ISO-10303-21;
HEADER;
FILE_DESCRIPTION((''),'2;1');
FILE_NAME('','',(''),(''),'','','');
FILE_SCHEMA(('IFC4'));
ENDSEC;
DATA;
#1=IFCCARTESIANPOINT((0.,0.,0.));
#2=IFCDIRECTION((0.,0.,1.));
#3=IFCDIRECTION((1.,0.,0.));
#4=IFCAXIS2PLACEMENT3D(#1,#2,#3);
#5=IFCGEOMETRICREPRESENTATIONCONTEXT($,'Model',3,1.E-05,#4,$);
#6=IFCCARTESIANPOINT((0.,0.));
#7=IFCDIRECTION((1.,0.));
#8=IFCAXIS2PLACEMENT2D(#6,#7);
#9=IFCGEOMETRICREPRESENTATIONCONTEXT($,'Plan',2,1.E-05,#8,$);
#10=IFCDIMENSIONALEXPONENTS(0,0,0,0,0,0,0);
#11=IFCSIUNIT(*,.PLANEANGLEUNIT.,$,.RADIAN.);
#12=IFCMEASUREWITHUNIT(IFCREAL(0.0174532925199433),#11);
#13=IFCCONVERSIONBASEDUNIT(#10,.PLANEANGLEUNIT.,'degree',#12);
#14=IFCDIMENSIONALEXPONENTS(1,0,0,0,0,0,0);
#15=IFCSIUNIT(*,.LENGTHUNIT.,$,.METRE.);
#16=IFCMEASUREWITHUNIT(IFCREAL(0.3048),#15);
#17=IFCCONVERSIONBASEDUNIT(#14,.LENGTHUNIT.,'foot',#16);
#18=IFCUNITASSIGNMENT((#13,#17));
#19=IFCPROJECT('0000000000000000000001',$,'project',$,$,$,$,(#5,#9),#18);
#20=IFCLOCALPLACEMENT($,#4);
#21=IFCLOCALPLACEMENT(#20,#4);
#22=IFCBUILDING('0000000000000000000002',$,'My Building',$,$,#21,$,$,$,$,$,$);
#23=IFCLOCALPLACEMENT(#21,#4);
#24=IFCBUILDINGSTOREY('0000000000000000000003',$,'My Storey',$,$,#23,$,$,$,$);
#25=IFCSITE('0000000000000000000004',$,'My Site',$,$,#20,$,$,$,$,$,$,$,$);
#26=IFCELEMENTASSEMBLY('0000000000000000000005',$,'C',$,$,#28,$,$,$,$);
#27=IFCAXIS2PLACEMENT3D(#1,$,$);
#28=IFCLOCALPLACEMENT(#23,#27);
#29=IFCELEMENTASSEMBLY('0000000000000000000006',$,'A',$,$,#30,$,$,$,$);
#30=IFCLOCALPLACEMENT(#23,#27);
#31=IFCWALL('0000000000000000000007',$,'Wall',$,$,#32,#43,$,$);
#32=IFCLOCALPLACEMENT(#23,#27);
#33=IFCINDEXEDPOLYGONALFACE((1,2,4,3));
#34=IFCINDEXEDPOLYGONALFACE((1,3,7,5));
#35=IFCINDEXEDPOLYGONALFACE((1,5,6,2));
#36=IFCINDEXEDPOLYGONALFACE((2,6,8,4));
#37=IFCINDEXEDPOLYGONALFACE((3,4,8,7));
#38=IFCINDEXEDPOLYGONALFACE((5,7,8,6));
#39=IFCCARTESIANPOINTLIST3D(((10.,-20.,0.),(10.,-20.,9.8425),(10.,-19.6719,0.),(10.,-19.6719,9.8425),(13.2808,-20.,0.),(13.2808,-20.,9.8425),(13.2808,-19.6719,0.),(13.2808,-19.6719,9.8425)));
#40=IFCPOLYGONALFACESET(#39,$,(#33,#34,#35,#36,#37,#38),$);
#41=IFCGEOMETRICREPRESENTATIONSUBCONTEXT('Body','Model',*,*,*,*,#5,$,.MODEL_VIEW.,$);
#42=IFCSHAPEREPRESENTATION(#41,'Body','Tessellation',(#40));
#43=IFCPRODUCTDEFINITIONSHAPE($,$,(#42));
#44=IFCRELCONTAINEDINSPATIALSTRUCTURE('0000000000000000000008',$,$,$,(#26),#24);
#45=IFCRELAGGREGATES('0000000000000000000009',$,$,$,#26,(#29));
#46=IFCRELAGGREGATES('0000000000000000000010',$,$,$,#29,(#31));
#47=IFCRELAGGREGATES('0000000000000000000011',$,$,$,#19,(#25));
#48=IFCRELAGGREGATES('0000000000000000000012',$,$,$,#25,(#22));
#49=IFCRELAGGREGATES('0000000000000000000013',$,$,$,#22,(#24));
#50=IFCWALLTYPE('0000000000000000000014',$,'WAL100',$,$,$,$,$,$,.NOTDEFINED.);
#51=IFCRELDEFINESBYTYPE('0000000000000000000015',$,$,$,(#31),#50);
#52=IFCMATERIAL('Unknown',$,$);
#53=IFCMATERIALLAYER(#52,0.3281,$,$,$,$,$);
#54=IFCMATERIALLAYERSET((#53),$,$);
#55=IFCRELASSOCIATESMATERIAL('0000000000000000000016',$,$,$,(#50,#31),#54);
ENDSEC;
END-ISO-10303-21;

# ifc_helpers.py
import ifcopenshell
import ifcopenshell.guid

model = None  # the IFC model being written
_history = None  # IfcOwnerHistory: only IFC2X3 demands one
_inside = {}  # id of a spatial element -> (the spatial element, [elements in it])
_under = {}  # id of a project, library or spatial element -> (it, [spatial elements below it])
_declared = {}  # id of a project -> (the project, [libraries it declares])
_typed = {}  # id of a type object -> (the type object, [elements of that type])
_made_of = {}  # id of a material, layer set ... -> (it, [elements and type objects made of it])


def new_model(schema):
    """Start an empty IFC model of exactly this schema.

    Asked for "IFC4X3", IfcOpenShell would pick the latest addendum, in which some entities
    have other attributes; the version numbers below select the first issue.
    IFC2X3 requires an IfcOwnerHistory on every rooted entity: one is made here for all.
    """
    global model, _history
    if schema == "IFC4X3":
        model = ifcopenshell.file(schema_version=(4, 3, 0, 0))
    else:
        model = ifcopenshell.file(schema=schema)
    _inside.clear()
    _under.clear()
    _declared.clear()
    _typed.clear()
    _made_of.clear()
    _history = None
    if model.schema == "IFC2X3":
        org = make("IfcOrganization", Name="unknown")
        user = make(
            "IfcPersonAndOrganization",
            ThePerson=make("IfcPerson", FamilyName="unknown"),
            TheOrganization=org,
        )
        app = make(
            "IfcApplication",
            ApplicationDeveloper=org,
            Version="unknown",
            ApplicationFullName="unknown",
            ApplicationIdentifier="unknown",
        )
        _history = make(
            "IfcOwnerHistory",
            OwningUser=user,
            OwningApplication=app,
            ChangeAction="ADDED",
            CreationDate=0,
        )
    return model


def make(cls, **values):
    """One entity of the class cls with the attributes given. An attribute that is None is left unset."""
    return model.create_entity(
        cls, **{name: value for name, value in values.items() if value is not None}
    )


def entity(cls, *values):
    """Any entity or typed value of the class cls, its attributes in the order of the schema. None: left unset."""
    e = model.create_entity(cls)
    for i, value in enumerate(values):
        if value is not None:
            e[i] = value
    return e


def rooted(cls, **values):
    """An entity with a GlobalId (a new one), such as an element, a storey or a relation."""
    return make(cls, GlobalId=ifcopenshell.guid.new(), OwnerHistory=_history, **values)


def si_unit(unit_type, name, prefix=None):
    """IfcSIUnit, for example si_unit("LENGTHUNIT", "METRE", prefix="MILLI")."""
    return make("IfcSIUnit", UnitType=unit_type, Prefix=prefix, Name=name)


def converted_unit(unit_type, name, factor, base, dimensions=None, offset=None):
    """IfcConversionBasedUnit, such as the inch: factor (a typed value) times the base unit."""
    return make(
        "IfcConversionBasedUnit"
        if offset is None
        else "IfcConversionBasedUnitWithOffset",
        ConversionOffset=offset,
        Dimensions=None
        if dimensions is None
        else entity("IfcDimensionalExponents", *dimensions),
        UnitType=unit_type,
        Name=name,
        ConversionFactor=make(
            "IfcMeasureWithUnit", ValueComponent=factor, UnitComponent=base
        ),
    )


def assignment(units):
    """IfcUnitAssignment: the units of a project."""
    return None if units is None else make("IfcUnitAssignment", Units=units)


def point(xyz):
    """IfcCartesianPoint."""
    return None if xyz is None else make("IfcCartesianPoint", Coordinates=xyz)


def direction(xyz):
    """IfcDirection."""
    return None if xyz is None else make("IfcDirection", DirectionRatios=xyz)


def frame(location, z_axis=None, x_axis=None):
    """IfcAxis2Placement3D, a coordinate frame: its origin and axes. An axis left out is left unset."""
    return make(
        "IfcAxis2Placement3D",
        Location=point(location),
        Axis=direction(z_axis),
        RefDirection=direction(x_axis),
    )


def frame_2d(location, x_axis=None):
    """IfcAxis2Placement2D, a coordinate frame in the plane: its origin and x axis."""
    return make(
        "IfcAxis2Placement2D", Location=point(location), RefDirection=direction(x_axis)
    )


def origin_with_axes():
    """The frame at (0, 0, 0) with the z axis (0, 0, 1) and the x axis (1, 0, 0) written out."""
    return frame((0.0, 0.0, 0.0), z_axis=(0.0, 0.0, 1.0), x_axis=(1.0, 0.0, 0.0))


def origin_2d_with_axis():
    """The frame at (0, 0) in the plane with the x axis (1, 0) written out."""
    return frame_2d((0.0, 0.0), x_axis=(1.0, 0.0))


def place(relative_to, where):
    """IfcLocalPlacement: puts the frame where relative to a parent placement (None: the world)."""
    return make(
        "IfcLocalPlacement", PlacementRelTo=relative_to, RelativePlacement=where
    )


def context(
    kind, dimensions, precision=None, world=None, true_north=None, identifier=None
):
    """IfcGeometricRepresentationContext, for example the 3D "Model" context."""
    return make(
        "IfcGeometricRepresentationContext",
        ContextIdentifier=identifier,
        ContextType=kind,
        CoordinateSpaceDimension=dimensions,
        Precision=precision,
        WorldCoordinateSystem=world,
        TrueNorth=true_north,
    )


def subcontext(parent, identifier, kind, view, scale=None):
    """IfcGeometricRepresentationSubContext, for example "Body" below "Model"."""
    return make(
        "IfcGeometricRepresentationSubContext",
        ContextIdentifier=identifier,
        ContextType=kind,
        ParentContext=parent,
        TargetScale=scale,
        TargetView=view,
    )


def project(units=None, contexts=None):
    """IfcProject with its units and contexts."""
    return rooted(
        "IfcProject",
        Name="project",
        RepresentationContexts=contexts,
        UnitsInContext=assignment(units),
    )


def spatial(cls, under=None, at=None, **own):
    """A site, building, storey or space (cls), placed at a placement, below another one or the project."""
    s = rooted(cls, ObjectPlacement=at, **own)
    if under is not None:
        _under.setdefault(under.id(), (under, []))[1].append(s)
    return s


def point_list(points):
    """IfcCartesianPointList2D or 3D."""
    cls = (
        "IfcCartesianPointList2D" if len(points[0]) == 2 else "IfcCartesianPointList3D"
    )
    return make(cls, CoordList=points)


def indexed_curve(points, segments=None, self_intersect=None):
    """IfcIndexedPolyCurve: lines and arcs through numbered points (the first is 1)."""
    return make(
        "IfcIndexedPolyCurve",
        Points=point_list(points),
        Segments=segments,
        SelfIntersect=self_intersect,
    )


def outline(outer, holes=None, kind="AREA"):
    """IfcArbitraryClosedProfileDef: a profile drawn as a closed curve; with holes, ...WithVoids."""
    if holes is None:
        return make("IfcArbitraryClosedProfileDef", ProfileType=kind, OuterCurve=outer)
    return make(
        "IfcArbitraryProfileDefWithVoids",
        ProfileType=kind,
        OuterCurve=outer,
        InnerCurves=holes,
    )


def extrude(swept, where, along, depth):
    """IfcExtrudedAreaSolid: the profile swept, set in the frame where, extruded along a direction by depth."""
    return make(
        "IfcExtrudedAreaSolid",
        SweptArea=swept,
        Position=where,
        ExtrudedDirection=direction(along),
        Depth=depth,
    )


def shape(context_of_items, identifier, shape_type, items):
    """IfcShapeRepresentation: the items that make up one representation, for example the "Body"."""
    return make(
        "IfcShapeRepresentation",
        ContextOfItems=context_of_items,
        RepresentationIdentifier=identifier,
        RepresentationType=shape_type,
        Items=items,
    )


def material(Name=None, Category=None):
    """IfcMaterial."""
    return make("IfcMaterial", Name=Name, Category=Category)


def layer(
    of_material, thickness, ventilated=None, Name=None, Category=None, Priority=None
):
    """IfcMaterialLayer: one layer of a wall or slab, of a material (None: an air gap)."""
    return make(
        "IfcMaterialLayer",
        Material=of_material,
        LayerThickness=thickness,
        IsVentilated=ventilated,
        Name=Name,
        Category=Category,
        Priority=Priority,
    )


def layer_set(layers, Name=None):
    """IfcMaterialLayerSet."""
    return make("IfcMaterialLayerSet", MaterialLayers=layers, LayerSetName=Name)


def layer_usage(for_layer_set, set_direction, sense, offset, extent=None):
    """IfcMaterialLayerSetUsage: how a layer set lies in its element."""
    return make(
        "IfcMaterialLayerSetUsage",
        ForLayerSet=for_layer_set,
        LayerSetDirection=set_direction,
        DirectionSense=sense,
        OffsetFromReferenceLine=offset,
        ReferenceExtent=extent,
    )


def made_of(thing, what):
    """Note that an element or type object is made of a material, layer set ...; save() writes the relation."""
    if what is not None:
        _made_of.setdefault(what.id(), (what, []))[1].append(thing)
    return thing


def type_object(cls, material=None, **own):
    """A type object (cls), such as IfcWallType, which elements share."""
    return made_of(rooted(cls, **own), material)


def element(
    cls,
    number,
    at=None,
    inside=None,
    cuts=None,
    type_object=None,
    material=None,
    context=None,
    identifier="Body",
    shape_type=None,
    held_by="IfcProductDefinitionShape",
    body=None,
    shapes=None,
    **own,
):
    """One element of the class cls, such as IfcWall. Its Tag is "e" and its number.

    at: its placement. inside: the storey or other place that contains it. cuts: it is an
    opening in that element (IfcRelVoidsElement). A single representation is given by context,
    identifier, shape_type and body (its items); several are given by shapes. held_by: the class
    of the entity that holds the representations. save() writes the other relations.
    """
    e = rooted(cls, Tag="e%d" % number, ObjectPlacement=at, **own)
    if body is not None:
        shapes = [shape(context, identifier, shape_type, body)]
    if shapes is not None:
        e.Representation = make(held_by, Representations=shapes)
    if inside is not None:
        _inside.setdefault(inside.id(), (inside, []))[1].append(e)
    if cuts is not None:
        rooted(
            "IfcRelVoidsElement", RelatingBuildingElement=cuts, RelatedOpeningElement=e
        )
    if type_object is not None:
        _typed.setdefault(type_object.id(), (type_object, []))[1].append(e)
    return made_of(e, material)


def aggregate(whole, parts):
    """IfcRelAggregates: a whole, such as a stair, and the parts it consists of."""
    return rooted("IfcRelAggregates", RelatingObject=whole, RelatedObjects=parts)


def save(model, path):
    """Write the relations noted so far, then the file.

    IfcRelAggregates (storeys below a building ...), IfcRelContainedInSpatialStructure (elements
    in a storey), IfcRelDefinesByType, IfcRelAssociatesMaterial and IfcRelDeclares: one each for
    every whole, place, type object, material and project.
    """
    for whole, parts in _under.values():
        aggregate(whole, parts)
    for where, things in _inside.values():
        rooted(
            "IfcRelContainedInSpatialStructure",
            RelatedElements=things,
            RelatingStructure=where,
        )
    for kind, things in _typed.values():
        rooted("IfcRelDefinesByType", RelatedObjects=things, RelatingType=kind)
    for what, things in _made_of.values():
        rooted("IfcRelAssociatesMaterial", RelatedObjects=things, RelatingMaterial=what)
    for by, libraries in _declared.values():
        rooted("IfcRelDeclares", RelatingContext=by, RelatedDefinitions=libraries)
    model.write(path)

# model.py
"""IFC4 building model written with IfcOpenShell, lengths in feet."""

from ifc_helpers import new_model, entity, si_unit, converted_unit, frame, origin_with_axes, origin_2d_with_axis, place, context, subcontext, project, spatial, indexed_curve, outline, extrude, material, layer, layer_set, layer_usage, type_object, element, aggregate, save


model = new_model("IFC4")

# Units and contexts
model_context = context("Model", 3, precision=1e-05, world=origin_with_axes())
plan_context = context("Plan", 2, precision=1e-05, world=origin_2d_with_axis())
body_context = subcontext(model_context, "Body", "Model", "MODEL_VIEW")
ifc_project = project(units=[converted_unit("PLANEANGLEUNIT", "degree", entity("IfcReal", 0.0174532925199433), si_unit("PLANEANGLEUNIT", "RADIAN"), dimensions=[0, 0, 0, 0, 0, 0, 0]), converted_unit("LENGTHUNIT", "foot", entity("IfcReal", 0.3048), si_unit("LENGTHUNIT", "METRE"), dimensions=[1, 0, 0, 0, 0, 0, 0])], contexts=[model_context, plan_context])

# Site, building, storey
site_placement = place(None, origin_with_axes())
site = spatial("IfcSite", under=ifc_project, at=site_placement, Name="My Site")
building_placement = place(site_placement, origin_with_axes())
building = spatial("IfcBuilding", under=site, at=building_placement, Name="My Building")
storey_placement = place(building_placement, origin_with_axes())
storey = spatial("IfcBuildingStorey", under=building, at=storey_placement, Name="My Storey")

# Shared definitions
ifc_material = material(Name="Unknown")
ifc_layer = layer(ifc_material, 0.3281)
ifc_layer_set = layer_set([ifc_layer])
wall_type = type_object("IfcWallType", Name="WAL100", PredefinedType="NOTDEFINED", material=ifc_layer_set)

# Element assemblies, wall
assembly_1_placement = place(storey_placement, frame((10.0, 0.0, 0.0), z_axis=(0.0, 0.0, 1.0), x_axis=(1.0, 0.0, 0.0)))
assembly_1 = element("IfcElementAssembly", 1, at=assembly_1_placement, inside=storey, Name="C")
assembly_2_placement = place(assembly_1_placement, frame((0.0, -20.0, 0.0), z_axis=(0.0, 0.0, 1.0), x_axis=(1.0, 0.0, 0.0)))
assembly_2 = element("IfcElementAssembly", 2, at=assembly_2_placement, Name="A")
aggregate(assembly_1, [assembly_2])
ifc_layer_usage_1 = layer_usage(ifc_layer_set, "AXIS2", "POSITIVE", 0.0)
wall_1_placement = place(assembly_2_placement, origin_with_axes())
wall_1 = element("IfcWall", 3, at=wall_1_placement, type_object=wall_type, material=ifc_layer_usage_1, Name="Wall", context=body_context, shape_type="SweptSolid", body=[
    extrude(outline(indexed_curve([(0.0, 0.0), (0.0, 0.3281), (3.2808, 0.3281), (3.2808, 0.0), (0.0, 0.0)], self_intersect=False)), origin_with_axes(), (0.0, 0.0, 1.0), 9.8425),
])
aggregate(assembly_2, [wall_1])

save(model, "model.ifc")
